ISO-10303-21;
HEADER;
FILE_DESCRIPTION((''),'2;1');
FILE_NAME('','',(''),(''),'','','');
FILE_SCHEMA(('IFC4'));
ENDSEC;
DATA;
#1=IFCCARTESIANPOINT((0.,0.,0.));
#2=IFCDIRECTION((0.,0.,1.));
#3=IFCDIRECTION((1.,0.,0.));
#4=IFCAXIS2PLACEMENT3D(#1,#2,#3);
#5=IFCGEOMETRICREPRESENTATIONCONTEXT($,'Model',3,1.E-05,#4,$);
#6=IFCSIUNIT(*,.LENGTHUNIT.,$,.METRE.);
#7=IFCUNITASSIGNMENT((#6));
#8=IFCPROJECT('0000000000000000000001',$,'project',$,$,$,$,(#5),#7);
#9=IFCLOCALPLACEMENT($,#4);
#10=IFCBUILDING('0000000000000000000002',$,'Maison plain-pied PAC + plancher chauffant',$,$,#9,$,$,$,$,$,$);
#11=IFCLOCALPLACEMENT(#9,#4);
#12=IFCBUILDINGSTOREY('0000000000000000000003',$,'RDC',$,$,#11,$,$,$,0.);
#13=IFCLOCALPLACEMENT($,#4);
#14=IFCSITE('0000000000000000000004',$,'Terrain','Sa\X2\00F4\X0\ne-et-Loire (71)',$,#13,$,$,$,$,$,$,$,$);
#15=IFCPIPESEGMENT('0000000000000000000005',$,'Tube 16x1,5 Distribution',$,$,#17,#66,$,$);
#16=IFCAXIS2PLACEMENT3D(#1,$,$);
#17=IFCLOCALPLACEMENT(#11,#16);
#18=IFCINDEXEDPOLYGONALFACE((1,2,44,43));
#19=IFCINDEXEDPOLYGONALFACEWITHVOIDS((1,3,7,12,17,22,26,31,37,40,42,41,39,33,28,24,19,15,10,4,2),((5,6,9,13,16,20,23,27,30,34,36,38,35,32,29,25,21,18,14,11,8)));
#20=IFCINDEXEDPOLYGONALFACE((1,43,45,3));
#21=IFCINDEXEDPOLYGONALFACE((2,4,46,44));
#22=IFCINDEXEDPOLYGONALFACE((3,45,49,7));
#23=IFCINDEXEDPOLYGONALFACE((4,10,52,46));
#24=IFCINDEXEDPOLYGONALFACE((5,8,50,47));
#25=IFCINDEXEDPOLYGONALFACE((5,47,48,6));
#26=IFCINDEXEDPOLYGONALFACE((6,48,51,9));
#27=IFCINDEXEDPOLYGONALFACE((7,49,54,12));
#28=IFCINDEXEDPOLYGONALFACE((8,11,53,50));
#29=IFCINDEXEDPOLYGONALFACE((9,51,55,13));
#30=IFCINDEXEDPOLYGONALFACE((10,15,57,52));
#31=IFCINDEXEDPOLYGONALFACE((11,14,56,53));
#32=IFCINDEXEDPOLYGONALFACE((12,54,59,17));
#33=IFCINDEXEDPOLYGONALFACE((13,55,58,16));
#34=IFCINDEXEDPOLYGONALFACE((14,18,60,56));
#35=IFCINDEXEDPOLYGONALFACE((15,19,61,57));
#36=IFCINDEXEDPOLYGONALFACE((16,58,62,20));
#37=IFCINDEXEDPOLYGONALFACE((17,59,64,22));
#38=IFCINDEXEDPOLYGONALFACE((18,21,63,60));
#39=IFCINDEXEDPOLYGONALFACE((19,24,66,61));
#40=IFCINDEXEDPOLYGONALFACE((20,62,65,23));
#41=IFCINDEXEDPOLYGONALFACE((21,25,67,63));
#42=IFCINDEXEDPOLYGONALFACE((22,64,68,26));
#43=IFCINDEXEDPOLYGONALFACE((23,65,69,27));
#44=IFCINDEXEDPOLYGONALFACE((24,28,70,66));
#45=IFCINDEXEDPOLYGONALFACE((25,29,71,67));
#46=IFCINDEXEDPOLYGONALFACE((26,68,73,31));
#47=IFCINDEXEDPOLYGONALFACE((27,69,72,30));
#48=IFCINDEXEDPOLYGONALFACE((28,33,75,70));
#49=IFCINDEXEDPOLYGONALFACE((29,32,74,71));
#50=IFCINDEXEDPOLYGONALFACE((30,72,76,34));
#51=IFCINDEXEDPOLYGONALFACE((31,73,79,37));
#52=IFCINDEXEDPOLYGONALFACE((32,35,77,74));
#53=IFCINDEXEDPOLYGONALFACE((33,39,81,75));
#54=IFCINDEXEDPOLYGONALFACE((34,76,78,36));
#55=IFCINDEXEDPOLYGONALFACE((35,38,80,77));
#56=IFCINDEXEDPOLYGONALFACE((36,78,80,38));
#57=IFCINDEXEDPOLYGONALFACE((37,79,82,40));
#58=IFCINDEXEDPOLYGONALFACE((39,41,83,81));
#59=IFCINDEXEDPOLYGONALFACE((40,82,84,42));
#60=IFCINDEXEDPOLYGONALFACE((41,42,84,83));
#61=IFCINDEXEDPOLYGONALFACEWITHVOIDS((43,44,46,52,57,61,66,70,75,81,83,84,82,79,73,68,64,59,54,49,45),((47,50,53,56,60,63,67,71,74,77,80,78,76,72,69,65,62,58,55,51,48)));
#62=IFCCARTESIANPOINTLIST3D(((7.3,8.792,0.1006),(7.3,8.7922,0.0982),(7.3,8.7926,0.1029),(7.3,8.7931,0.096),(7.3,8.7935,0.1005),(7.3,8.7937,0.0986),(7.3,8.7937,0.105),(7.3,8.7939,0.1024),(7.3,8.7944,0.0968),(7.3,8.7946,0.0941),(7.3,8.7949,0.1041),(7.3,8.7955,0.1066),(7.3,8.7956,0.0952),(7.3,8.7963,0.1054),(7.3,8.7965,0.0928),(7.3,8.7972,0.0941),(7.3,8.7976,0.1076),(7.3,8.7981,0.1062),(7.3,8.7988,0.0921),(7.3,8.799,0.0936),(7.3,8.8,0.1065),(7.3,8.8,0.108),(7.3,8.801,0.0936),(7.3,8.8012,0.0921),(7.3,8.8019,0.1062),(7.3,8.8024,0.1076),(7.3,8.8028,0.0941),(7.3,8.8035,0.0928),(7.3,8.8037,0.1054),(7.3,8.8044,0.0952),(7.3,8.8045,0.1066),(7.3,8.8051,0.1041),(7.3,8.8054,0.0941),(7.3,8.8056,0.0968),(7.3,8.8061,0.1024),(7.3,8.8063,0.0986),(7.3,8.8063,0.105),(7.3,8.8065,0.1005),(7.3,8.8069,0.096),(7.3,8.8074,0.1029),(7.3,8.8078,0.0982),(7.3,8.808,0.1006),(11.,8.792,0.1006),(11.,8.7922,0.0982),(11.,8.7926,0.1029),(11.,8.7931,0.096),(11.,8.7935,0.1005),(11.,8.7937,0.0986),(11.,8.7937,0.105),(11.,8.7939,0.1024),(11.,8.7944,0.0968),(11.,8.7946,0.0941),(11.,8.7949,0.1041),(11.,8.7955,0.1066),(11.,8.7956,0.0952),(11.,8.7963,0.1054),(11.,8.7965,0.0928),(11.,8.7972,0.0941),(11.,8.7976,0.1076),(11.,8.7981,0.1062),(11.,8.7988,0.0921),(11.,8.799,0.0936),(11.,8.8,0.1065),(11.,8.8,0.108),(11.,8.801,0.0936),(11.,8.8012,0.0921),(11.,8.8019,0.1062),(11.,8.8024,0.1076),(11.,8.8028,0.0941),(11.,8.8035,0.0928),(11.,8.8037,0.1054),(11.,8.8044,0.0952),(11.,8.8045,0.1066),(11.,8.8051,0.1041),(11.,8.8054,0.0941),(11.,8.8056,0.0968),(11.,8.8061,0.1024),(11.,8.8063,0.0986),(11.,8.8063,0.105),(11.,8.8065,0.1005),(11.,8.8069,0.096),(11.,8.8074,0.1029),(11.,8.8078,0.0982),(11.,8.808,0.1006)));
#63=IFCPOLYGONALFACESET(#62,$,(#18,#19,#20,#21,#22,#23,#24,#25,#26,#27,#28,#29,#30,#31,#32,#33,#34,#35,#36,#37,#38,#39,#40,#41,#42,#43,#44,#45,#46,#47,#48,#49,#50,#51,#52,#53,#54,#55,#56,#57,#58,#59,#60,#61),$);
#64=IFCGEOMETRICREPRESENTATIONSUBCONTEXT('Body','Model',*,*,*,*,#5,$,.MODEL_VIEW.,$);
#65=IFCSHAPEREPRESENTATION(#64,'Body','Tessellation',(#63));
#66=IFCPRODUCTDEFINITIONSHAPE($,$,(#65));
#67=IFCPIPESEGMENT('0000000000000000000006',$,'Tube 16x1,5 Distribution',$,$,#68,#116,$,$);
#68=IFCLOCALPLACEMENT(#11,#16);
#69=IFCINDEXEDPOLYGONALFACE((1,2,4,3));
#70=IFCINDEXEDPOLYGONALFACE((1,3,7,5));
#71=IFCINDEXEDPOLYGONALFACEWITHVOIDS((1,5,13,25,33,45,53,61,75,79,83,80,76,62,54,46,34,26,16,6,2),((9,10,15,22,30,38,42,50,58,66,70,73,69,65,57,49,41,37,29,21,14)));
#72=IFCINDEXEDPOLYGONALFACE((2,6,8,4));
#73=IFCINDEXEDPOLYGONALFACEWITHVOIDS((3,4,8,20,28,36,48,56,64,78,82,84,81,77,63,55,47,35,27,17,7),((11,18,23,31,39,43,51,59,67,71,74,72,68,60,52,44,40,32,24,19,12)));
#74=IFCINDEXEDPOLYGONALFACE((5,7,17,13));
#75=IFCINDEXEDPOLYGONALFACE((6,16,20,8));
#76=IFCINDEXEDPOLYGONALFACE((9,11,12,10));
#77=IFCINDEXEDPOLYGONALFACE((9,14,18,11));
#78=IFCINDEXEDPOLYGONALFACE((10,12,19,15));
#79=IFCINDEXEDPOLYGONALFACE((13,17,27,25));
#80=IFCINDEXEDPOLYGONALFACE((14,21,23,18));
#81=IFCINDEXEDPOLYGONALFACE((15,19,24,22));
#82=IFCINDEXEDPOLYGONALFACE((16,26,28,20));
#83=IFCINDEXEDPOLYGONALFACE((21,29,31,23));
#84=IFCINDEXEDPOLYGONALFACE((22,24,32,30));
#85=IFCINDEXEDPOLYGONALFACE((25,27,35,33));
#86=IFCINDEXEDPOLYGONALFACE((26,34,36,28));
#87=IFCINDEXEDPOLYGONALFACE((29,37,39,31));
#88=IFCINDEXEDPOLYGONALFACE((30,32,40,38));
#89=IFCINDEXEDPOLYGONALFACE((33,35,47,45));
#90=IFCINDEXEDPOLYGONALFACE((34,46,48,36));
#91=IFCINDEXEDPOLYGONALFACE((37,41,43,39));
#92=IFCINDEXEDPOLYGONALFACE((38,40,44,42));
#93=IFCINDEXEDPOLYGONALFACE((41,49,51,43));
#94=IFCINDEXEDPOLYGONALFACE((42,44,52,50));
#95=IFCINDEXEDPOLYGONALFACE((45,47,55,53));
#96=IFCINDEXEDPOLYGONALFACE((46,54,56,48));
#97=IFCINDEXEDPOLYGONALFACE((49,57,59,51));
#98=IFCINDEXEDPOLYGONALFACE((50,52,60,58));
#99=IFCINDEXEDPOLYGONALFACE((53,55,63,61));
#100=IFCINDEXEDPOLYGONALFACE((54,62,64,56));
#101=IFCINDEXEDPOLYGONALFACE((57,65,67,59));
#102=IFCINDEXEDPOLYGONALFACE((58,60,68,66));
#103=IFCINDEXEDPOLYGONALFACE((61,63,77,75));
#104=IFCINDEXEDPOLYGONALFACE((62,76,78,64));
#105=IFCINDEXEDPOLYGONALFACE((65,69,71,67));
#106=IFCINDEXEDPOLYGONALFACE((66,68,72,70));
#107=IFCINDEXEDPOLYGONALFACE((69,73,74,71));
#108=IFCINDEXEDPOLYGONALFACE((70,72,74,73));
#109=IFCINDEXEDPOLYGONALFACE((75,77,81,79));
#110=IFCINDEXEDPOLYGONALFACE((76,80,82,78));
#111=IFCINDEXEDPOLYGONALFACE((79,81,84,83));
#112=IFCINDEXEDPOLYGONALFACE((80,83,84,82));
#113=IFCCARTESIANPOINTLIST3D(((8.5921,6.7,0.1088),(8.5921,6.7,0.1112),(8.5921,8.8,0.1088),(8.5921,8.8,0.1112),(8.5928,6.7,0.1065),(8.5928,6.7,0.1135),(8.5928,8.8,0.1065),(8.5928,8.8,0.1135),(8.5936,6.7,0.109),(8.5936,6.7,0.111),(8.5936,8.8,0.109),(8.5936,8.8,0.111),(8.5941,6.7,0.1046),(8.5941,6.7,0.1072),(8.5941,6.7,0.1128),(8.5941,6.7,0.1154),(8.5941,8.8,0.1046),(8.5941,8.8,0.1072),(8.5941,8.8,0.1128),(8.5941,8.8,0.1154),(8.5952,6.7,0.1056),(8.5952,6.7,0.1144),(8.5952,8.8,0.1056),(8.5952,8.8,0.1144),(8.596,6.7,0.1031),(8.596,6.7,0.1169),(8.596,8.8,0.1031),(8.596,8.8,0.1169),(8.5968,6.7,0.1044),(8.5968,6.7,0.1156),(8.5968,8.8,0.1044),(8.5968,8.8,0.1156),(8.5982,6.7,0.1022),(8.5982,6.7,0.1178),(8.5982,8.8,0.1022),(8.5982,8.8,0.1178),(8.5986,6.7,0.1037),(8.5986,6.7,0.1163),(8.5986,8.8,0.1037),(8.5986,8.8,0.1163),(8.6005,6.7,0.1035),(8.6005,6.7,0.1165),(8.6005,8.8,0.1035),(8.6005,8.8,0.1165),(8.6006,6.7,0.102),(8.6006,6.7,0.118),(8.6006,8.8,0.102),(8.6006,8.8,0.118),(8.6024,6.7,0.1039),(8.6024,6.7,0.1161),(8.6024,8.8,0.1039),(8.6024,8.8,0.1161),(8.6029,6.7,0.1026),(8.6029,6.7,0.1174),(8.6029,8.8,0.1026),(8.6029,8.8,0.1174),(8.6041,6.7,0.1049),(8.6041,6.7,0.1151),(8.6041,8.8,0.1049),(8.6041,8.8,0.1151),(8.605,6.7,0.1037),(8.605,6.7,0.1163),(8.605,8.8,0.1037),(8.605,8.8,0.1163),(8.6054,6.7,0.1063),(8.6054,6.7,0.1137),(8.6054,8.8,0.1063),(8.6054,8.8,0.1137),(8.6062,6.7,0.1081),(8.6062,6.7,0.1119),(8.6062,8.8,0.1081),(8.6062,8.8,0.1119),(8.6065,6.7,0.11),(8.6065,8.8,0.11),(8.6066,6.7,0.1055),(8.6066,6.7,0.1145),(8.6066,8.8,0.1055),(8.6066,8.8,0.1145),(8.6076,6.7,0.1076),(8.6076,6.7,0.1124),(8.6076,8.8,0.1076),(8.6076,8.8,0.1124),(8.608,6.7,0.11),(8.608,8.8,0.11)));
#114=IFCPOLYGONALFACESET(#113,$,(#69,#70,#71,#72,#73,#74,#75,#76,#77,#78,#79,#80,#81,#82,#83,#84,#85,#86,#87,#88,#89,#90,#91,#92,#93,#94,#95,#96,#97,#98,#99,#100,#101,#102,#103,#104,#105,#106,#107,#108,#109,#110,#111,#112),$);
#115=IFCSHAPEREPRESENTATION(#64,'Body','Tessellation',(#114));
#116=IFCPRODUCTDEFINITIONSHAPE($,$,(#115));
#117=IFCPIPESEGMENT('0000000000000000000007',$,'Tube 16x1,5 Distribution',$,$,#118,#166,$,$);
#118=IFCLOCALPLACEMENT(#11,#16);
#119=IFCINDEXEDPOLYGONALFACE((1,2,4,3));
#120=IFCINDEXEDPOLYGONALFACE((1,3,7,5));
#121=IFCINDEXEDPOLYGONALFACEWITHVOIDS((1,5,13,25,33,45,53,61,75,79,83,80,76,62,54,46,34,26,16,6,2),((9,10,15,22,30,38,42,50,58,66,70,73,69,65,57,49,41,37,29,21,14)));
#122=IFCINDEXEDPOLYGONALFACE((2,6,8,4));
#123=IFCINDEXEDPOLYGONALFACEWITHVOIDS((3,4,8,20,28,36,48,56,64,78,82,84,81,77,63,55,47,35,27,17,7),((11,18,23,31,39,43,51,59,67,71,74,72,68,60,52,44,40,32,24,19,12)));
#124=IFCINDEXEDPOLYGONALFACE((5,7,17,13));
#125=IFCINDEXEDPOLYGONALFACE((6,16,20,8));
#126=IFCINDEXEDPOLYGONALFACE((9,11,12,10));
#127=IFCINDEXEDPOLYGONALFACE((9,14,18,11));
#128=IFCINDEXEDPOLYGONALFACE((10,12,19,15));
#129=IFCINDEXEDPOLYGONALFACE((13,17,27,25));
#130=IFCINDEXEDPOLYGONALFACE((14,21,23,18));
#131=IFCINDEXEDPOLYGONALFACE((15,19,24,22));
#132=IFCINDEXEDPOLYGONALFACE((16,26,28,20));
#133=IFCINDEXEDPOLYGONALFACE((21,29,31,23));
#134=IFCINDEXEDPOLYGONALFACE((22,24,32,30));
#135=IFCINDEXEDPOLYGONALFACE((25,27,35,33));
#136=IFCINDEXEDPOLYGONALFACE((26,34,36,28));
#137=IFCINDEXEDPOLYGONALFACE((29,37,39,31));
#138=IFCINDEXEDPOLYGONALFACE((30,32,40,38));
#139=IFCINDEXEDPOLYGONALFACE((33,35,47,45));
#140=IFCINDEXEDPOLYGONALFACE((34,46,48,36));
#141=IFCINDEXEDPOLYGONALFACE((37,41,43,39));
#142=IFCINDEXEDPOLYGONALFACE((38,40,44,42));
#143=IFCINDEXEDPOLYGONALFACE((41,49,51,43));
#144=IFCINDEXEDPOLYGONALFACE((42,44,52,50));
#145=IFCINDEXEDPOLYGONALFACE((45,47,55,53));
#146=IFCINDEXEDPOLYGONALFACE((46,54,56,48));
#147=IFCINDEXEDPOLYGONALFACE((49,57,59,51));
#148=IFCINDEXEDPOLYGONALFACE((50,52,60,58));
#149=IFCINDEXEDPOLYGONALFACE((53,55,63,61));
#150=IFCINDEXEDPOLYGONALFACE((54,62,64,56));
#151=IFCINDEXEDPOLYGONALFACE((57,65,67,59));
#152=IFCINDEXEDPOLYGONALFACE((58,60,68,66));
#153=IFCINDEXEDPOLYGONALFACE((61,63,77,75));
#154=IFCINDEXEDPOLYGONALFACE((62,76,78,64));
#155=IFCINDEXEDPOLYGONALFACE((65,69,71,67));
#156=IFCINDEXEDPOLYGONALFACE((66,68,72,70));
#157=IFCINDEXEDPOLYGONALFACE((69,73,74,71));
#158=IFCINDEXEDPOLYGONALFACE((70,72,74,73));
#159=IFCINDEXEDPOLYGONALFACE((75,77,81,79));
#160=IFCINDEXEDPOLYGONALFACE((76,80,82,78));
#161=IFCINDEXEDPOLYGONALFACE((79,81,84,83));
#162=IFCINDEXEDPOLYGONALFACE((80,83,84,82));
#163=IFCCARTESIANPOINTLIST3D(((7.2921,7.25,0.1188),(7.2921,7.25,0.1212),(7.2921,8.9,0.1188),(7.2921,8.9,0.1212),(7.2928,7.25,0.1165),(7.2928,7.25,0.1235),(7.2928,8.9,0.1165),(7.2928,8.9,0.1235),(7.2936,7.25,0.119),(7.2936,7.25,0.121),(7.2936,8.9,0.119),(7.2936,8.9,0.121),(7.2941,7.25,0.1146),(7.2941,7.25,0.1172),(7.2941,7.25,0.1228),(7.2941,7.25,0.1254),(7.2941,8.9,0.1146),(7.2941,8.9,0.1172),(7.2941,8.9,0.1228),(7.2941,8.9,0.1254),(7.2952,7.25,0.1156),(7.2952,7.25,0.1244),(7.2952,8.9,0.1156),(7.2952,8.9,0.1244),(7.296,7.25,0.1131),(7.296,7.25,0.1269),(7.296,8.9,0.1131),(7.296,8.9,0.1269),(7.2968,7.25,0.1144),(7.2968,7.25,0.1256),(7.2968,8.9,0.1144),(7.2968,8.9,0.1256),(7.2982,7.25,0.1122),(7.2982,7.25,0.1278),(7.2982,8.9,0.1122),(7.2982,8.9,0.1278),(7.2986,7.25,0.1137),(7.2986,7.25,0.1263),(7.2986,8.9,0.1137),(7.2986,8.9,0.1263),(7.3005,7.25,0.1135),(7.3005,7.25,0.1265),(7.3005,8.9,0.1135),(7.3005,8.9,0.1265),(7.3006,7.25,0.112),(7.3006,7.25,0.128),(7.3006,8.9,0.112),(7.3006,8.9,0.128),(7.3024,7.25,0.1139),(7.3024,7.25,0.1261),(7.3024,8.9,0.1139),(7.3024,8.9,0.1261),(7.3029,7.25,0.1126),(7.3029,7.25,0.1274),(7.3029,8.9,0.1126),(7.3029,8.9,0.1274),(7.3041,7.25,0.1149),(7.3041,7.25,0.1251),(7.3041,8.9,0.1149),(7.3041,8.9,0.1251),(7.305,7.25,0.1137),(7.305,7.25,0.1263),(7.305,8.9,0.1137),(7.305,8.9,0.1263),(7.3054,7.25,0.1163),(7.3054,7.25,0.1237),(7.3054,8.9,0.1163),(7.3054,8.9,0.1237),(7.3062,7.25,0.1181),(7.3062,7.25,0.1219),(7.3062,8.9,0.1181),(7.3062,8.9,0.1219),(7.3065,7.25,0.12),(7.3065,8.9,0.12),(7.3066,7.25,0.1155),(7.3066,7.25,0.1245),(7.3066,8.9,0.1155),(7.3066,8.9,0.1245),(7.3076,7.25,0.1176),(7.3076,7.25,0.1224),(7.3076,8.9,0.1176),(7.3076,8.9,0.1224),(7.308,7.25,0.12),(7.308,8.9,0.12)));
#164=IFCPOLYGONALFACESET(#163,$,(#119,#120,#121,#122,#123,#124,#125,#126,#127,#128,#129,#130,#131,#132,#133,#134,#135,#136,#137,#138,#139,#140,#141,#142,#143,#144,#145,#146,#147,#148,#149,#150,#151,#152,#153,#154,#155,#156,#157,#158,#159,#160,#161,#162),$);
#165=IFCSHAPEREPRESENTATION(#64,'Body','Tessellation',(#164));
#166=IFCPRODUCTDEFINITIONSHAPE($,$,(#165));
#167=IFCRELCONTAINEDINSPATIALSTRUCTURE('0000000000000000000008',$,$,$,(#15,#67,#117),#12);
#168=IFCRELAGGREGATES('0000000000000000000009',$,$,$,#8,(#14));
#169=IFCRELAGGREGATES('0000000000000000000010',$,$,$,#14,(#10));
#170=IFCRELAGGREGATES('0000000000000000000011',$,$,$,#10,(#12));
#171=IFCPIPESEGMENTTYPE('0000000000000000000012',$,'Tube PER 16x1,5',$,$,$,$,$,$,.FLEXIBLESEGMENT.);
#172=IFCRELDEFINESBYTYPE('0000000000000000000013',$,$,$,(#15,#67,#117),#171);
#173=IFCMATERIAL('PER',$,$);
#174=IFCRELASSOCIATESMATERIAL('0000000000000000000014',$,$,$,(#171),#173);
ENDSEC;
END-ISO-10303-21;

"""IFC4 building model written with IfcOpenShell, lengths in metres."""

from ifc_helpers import new_model, si_unit, frame, origin_with_axes, place, context, subcontext, project, spatial, hollow_circle, extrude, material, type_object, element, save


model = new_model("IFC4")

# Units and contexts
model_context = context("Model", 3, precision=1e-05, world=origin_with_axes())
body_context = subcontext(model_context, "Body", "Model", "MODEL_VIEW")
ifc_project = project(units=[si_unit("LENGTHUNIT", "METRE")], contexts=[model_context])

# Site, building, storey
site_placement = place(None, origin_with_axes())
site = spatial("IfcSite", under=ifc_project, at=site_placement, Name="Terrain", Description="Saône-et-Loire (71)")
building_placement = place(None, origin_with_axes())
building = spatial("IfcBuilding", under=site, at=building_placement, Name="Maison plain-pied PAC + plancher chauffant")
storey_placement = place(building_placement, origin_with_axes())
storey = spatial("IfcBuildingStorey", under=building, at=storey_placement, Name="RDC", Elevation=0.0)

# Pipe segments
ifc_material_1 = material(Name="PER")
pipe_segment_type_1 = type_object("IfcPipeSegmentType", Name="Tube PER 16x1,5", PredefinedType="FLEXIBLESEGMENT", material=ifc_material_1)
pipe_segment_1_placement = place(storey_placement, frame((7.3, 8.8, 0.1), z_axis=(1.0, 0.0, 0.0), x_axis=(0.0, 0.0, 1.0)))
element("IfcPipeSegment", 1, at=pipe_segment_1_placement, inside=storey, type_object=pipe_segment_type_1, Name="Tube 16x1,5 Distribution", context=body_context, shape_type="SweptSolid", body=[
    extrude(hollow_circle(Radius=0.008, WallThickness=0.0015), origin_with_axes(), (0.0, 0.0, 1.0), 3.7),
])
pipe_segment_2_placement = place(storey_placement, frame((8.6, 6.7, 0.11), z_axis=(0.0, 1.0, 0.0), x_axis=(1.0, 0.0, 0.0)))
element("IfcPipeSegment", 2, at=pipe_segment_2_placement, inside=storey, type_object=pipe_segment_type_1, Name="Tube 16x1,5 Distribution", context=body_context, shape_type="SweptSolid", body=[
    extrude(hollow_circle(Radius=0.008, WallThickness=0.0015), origin_with_axes(), (0.0, 0.0, 1.0), 2.1),
])
pipe_segment_3_placement = place(storey_placement, frame((7.3, 7.25, 0.12), z_axis=(0.0, 1.0, 0.0), x_axis=(1.0, 0.0, 0.0)))
element("IfcPipeSegment", 3, at=pipe_segment_3_placement, inside=storey, type_object=pipe_segment_type_1, Name="Tube 16x1,5 Distribution", context=body_context, shape_type="SweptSolid", body=[
    extrude(hollow_circle(Radius=0.008, WallThickness=0.0015), origin_with_axes(), (0.0, 0.0, 1.0), 1.65),
])

save(model, "model.ifc")
